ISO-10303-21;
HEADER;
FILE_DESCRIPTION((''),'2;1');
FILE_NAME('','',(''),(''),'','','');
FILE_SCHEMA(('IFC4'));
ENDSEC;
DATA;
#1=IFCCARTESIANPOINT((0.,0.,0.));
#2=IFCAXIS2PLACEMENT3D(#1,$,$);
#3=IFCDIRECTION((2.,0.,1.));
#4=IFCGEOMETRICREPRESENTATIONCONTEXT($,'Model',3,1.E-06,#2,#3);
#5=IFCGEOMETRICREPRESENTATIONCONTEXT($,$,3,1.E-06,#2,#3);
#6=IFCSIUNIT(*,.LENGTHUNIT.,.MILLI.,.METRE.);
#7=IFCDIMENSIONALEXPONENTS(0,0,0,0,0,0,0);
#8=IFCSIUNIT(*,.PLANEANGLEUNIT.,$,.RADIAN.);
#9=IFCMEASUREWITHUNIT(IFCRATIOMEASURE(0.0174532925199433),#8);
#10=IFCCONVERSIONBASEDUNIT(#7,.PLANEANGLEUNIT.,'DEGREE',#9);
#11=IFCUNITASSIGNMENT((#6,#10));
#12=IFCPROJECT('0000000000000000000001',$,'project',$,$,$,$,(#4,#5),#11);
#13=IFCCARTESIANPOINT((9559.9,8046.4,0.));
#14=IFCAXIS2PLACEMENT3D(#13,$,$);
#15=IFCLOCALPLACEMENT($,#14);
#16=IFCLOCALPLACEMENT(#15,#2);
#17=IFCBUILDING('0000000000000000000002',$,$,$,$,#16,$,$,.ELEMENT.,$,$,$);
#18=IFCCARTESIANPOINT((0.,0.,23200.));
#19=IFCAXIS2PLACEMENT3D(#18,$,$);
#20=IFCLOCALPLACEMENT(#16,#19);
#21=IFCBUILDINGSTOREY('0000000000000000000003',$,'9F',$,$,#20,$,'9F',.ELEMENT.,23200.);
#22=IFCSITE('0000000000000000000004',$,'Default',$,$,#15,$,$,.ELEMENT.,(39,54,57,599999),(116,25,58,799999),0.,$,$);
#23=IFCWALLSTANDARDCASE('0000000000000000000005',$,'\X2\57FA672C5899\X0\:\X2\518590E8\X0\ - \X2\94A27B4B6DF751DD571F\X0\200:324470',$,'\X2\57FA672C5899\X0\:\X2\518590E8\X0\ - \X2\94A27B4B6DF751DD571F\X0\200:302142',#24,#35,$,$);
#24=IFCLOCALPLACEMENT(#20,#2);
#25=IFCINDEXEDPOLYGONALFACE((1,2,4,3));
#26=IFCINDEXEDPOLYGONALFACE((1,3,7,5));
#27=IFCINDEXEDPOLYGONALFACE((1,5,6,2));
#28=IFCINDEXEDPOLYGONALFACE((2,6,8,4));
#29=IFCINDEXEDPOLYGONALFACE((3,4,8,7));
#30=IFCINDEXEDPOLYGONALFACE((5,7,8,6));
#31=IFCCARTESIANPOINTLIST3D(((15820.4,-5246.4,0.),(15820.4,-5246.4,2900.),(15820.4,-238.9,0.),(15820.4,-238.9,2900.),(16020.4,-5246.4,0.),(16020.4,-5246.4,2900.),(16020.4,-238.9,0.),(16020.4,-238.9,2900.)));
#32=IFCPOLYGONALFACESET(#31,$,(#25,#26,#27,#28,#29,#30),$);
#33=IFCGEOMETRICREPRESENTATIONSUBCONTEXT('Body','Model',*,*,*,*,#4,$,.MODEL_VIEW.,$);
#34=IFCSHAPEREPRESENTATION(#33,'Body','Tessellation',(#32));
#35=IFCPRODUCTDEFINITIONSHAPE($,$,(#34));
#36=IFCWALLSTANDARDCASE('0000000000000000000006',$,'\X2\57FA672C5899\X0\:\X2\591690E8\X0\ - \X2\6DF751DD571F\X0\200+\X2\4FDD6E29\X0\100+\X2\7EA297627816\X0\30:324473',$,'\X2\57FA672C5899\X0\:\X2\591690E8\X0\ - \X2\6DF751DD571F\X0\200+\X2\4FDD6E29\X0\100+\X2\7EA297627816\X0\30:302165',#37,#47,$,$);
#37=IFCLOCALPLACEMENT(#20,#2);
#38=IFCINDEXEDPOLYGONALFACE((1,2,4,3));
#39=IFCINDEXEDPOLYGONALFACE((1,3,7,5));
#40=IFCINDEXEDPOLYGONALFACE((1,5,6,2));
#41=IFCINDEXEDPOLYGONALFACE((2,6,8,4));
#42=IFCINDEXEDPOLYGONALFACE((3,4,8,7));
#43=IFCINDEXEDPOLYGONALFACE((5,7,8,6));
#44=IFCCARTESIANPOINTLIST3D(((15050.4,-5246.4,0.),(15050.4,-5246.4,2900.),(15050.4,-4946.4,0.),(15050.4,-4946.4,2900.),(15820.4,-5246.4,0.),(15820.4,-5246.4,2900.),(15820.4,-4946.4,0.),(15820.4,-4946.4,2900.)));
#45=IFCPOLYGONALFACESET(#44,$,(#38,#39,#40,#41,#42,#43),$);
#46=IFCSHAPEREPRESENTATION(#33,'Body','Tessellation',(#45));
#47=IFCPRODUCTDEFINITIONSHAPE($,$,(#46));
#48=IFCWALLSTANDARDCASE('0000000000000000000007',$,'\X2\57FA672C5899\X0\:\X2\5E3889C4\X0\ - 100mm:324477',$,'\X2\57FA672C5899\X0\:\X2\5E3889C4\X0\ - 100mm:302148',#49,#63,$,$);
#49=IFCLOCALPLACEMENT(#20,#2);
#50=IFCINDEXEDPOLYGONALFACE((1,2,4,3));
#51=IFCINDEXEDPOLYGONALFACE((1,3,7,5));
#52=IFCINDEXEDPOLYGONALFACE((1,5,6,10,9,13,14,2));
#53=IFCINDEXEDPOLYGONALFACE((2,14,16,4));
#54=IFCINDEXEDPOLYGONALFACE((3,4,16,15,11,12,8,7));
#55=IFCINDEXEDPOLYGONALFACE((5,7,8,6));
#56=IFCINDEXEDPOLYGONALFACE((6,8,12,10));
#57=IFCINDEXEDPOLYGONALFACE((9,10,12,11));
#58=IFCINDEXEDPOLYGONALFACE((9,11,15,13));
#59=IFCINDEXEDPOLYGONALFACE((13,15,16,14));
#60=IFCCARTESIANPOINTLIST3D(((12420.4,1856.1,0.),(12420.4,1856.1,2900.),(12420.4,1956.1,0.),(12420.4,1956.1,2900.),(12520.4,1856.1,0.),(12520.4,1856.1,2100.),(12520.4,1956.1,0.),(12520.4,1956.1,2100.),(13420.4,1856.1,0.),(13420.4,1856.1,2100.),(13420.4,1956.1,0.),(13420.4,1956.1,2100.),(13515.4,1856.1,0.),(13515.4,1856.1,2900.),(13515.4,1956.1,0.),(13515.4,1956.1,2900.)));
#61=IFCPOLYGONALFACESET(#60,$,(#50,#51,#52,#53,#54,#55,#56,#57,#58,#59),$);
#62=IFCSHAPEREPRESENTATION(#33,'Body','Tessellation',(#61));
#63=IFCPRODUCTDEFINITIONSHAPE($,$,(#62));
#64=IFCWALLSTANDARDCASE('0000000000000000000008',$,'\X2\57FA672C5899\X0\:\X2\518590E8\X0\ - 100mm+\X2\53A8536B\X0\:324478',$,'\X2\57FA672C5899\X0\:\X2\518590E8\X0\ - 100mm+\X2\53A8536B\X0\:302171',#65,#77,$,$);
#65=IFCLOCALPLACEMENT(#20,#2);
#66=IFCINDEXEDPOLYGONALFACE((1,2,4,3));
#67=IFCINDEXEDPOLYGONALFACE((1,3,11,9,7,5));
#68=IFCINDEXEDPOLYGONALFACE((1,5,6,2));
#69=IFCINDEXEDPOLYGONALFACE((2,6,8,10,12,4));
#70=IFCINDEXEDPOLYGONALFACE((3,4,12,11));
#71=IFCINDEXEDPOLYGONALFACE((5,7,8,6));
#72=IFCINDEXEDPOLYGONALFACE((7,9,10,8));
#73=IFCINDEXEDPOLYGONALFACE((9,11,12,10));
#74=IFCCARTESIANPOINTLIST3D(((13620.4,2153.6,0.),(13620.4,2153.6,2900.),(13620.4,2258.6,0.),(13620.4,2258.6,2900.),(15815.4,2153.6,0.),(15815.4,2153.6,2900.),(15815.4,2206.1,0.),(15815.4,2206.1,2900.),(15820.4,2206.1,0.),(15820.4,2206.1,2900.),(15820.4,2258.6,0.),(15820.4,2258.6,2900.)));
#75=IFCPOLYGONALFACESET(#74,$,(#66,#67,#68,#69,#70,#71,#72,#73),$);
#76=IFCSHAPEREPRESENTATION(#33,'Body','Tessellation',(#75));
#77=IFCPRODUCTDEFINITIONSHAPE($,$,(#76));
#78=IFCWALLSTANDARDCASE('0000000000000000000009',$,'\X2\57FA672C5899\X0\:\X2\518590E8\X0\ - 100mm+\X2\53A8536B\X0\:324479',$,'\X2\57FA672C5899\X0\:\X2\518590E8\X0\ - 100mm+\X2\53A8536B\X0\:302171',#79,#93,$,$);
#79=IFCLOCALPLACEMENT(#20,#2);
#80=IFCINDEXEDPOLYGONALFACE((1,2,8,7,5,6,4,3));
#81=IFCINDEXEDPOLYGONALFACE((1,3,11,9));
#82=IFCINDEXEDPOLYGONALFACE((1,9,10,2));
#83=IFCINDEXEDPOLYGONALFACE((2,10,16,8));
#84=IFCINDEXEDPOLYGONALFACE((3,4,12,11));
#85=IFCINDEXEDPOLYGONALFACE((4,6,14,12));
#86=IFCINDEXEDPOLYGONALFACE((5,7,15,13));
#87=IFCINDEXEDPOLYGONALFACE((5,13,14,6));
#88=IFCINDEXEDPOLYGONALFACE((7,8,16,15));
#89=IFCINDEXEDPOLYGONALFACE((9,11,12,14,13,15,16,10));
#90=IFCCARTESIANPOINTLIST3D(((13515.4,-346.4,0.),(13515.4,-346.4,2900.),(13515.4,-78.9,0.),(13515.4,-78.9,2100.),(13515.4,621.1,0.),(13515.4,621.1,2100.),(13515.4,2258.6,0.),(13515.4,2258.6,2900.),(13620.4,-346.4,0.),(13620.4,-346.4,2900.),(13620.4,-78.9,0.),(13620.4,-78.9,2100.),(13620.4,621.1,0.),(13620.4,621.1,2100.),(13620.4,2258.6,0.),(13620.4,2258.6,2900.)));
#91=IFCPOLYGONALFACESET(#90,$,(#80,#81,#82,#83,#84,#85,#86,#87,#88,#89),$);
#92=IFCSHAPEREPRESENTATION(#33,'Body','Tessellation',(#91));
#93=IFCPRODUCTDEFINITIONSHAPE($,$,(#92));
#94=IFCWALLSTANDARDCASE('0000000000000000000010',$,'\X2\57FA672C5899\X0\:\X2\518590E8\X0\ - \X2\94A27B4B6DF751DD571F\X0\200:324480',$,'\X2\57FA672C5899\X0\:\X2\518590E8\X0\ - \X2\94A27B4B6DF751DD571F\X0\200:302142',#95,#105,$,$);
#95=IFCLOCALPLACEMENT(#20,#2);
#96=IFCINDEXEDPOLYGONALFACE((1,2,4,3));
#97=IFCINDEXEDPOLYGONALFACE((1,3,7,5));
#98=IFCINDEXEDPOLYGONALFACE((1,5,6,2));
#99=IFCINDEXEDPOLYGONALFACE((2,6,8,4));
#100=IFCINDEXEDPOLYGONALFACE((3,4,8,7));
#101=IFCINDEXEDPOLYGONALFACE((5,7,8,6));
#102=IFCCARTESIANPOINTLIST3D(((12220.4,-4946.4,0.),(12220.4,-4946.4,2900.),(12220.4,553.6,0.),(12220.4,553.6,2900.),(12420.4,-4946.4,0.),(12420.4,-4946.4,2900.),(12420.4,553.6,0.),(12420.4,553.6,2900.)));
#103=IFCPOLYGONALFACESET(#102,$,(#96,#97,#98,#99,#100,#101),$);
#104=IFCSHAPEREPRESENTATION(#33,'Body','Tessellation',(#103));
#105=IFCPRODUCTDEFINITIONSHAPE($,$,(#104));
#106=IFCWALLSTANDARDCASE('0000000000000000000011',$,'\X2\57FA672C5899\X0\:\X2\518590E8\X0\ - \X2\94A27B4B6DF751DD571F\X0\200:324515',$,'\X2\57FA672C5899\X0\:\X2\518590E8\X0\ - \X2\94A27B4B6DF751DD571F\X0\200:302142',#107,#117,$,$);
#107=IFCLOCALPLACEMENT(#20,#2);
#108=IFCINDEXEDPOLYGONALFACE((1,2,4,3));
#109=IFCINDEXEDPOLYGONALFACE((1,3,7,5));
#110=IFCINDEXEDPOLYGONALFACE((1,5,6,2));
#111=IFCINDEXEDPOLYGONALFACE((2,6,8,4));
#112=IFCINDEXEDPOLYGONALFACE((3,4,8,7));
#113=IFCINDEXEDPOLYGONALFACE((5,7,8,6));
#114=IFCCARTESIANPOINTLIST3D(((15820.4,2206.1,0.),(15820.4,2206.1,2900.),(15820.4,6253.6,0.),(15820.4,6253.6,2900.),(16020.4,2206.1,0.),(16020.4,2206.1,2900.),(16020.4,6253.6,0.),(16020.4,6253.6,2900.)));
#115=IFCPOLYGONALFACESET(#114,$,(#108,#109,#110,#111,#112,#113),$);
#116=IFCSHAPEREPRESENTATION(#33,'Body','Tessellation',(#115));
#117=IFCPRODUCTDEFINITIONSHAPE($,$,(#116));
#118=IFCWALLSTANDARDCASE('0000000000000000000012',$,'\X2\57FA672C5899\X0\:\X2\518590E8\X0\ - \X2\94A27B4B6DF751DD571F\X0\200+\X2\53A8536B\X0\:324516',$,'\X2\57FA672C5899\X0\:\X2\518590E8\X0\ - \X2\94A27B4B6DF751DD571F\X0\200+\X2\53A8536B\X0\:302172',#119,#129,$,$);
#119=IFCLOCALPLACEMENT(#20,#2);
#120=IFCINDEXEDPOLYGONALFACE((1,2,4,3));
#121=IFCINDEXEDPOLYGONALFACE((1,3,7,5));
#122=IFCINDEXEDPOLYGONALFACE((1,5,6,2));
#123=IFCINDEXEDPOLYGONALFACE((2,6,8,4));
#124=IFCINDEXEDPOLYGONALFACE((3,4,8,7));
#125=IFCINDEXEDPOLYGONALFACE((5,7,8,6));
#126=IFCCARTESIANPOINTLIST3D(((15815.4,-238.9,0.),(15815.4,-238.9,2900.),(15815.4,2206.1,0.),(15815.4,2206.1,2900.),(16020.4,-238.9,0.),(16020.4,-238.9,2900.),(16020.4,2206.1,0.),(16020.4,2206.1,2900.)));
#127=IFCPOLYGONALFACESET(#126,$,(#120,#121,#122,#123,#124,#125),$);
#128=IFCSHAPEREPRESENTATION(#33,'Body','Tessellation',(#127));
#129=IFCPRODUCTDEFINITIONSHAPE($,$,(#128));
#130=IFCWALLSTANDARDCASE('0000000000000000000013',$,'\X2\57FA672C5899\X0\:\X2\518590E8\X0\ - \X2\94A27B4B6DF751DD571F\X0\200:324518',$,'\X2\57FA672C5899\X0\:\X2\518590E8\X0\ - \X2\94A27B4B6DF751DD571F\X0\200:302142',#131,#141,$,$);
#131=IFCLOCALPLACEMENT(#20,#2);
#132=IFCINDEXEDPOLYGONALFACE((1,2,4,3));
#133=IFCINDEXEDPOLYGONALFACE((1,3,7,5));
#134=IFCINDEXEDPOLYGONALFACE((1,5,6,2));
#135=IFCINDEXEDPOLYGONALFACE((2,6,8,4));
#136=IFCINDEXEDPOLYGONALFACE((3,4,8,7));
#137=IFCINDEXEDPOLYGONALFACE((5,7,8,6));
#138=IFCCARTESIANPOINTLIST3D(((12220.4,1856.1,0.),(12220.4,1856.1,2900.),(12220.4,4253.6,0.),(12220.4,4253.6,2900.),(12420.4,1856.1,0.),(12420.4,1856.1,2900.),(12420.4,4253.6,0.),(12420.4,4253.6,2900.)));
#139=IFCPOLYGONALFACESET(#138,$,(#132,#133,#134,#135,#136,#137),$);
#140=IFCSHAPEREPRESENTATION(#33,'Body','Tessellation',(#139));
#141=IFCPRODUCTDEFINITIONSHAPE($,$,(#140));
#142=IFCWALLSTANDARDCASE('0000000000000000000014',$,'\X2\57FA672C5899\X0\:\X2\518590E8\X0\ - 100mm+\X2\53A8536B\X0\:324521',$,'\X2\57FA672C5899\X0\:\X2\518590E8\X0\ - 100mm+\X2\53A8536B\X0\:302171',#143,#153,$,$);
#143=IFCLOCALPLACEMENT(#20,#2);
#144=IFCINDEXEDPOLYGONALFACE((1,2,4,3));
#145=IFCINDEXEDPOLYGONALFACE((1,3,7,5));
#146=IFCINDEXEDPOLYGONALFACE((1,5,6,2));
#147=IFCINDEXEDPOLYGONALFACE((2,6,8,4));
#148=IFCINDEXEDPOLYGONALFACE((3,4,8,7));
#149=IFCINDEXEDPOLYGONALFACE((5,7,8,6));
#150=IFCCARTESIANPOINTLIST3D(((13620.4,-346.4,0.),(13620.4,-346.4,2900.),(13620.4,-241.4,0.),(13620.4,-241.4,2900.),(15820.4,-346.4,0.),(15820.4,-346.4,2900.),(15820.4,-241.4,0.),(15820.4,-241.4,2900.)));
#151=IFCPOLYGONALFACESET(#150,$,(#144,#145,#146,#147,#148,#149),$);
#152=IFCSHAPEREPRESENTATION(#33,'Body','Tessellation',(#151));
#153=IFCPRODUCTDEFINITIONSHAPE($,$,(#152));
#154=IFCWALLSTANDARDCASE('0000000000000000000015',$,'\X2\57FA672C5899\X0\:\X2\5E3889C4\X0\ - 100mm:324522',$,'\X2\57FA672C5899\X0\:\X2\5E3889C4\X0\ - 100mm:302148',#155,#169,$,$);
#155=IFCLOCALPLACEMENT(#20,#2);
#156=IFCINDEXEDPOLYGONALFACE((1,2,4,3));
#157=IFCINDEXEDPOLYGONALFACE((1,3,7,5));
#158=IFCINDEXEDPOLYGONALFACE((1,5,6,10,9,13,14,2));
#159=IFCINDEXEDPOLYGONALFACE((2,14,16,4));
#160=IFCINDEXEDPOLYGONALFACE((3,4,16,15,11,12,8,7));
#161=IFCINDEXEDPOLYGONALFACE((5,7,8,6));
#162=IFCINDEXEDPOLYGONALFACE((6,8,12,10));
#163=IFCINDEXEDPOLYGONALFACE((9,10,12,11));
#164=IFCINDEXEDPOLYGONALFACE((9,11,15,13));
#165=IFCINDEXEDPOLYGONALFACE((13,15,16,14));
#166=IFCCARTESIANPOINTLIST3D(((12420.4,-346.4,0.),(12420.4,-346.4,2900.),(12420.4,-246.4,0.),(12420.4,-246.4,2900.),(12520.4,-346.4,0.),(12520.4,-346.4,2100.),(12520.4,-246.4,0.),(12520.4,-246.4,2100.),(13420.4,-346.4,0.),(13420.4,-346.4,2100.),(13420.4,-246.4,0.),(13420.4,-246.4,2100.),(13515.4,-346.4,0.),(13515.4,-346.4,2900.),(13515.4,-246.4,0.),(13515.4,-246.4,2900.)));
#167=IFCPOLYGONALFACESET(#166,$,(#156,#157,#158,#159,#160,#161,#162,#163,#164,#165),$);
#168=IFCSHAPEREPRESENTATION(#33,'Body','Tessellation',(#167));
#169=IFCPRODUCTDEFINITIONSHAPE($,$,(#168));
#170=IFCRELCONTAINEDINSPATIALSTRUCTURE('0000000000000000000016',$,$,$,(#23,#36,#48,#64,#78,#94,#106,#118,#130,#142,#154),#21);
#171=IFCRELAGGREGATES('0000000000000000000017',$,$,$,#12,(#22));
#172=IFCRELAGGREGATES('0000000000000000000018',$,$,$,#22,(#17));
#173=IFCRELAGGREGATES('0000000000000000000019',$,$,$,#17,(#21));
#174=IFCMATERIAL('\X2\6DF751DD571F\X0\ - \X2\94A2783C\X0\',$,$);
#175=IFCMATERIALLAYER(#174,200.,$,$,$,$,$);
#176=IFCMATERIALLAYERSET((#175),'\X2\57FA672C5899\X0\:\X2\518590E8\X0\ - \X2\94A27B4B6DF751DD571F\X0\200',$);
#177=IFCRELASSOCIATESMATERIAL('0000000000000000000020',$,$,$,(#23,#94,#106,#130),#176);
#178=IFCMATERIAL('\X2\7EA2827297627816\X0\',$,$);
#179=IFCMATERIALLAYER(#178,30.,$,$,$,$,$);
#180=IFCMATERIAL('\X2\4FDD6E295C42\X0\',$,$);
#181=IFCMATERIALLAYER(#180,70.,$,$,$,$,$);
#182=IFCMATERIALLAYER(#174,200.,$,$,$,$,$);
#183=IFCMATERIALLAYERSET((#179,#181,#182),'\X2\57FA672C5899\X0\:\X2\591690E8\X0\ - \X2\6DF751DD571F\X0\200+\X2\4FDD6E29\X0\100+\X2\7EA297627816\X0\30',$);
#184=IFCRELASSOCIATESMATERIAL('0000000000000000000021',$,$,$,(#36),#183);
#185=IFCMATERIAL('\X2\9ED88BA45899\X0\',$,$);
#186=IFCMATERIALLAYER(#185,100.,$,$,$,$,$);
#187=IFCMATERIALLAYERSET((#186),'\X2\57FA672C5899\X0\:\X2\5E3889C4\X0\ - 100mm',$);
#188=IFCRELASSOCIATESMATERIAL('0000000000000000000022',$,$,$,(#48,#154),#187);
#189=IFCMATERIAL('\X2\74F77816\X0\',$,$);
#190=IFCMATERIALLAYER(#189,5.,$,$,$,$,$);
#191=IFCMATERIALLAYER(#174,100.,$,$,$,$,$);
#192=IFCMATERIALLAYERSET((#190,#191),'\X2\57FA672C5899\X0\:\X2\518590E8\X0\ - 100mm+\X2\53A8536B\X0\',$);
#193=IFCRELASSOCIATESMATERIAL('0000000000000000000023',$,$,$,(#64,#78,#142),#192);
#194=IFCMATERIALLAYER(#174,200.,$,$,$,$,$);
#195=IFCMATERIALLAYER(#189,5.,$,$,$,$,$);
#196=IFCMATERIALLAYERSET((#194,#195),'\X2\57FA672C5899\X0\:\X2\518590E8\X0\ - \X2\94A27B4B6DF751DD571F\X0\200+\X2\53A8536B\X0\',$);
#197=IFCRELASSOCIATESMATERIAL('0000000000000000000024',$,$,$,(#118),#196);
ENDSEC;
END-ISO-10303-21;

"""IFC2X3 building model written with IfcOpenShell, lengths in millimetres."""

from ifc_helpers import new_model, entity, si_unit, converted_unit, direction, frame, frame_2d, origin, place, context, subcontext, project, spatial, polyline, rectangle, outline, extrude, material, layer, layer_set, layer_usage, element, save


model = new_model("IFC2X3")

# Units and contexts
model_context = context("Model", 3, precision=1e-06, world=origin(), true_north=direction((2.0, 0.0, 1.0)))
context_of_model = context(None, 3, precision=1e-06, world=origin(), true_north=direction((2.0, 0.0, 1.0)))
body_context = subcontext(model_context, "Body", "Model", "MODEL_VIEW")
ifc_project = project(units=[si_unit("LENGTHUNIT", "METRE", prefix="MILLI"), converted_unit("PLANEANGLEUNIT", "DEGREE", entity("IfcRatioMeasure", 0.0174532925199433), si_unit("PLANEANGLEUNIT", "RADIAN"), dimensions=[0, 0, 0, 0, 0, 0, 0])], contexts=[model_context, context_of_model])

# Site, building, storey
site_placement = place(None, frame((9559.9, 8046.4, 0.0)))
site = spatial("IfcSite", under=ifc_project, at=site_placement, Name="Default", CompositionType="ELEMENT", RefLatitude=(39, 54, 57, 599999), RefLongitude=(116, 25, 58, 799999), RefElevation=0.0)
building_placement = place(site_placement, origin())
building = spatial("IfcBuilding", under=site, at=building_placement, CompositionType="ELEMENT")
storey_placement = place(building_placement, frame((0.0, 0.0, 23200.0)))
storey = spatial("IfcBuildingStorey", under=building, at=storey_placement, Name="9F", LongName="9F", CompositionType="ELEMENT", Elevation=23200.0)

# Walls
ifc_material_1 = material(Name="混凝土 - 钢砼")
ifc_layer_1 = layer(ifc_material_1, 200.0)
ifc_layer_set_1 = layer_set([ifc_layer_1], Name="基本墙:内部 - 钢筋混凝土200")
ifc_layer_usage_1 = layer_usage(ifc_layer_set_1, "AXIS2", "POSITIVE", -100.0)
wall_1_placement = place(storey_placement, frame((15920.4, -5246.4, 0.0), z_axis=(0.0, 0.0, 1.0), x_axis=(0.0, 1.0, 0.0)))
element("IfcWallStandardCase", 1, at=wall_1_placement, inside=storey, material=ifc_layer_usage_1, Name="基本墙:内部 - 钢筋混凝土200:324470", ObjectType="基本墙:内部 - 钢筋混凝土200:302142", context=body_context, shape_type="SweptSolid", body=[
    extrude(rectangle(XDim=5007.5, YDim=200.0, at=frame_2d((2503.8, 0.0), x_axis=(-1.0, 0.0))), origin(), (0.0, 0.0, 1.0), 2900.0),
])
ifc_material_2 = material(Name="红色面砖")
ifc_layer_2 = layer(ifc_material_2, 30.0)
ifc_material_3 = material(Name="保温层")
ifc_layer_3 = layer(ifc_material_3, 70.0)
ifc_layer_4 = layer(ifc_material_1, 200.0)
ifc_layer_set_2 = layer_set([ifc_layer_2, ifc_layer_3, ifc_layer_4], Name="基本墙:外部 - 混凝土200+保温100+红面砖30")
ifc_layer_usage_2 = layer_usage(ifc_layer_set_2, "AXIS2", "NEGATIVE", 150.0)
wall_2_placement = place(storey_placement, frame((15820.4, -5096.4, 0.0), z_axis=(0.0, 0.0, 1.0), x_axis=(-1.0, 0.0, 0.0)))
element("IfcWallStandardCase", 2, at=wall_2_placement, inside=storey, material=ifc_layer_usage_2, Name="基本墙:外部 - 混凝土200+保温100+红面砖30:324473", ObjectType="基本墙:外部 - 混凝土200+保温100+红面砖30:302165", context=body_context, shape_type="SweptSolid", body=[
    extrude(rectangle(XDim=770.0, YDim=300.0, at=frame_2d((385.0, 0.0), x_axis=(-1.0, 0.0))), origin(), (0.0, 0.0, 1.0), 2900.0),
])

# Wall, opening
ifc_material_4 = material(Name="默认墙")
ifc_layer_5 = layer(ifc_material_4, 100.0)
ifc_layer_set_3 = layer_set([ifc_layer_5], Name="基本墙:常规 - 100mm")
ifc_layer_usage_3 = layer_usage(ifc_layer_set_3, "AXIS2", "POSITIVE", -50.0)
wall_3_placement = place(storey_placement, frame((13515.4, 1906.1, 0.0), z_axis=(0.0, 0.0, 1.0), x_axis=(-1.0, 0.0, 0.0)))
wall_3 = element("IfcWallStandardCase", 3, at=wall_3_placement, inside=storey, material=ifc_layer_usage_3, Name="基本墙:常规 - 100mm:324477", ObjectType="基本墙:常规 - 100mm:302148", context=body_context, shape_type="SweptSolid", body=[
    extrude(rectangle(XDim=1095.0, YDim=100.0, at=frame_2d((547.5, 0.0), x_axis=(-1.0, 0.0))), origin(), (0.0, 0.0, 1.0), 2900.0),
])
opening_1_placement = place(wall_3_placement, frame((995.0, 50.0, 0.0)))
element("IfcOpeningElement", 4, at=opening_1_placement, cuts=wall_3, ObjectType="Opening", context=body_context, shape_type="SweptSolid", body=[
    extrude(rectangle(XDim=2100.0, YDim=900.0, at=frame_2d((1050.0, 450.0), x_axis=(1.0, 0.0))), frame((0.0, 0.0, 0.0), z_axis=(0.0, -1.0, 0.0), x_axis=(0.0, 0.0, 1.0)), (0.0, 0.0, 1.0), 100.0),
])

# Wall
ifc_material_5 = material(Name="瓷砖")
ifc_layer_6 = layer(ifc_material_5, 5.0)
ifc_layer_7 = layer(ifc_material_1, 100.0)
ifc_layer_set_4 = layer_set([ifc_layer_6, ifc_layer_7], Name="基本墙:内部 - 100mm+厨卫")
ifc_layer_usage_4 = layer_usage(ifc_layer_set_4, "AXIS2", "NEGATIVE", 52.5)
wall_4_placement = place(storey_placement, frame((15820.4, 2206.1, 0.0), z_axis=(0.0, 0.0, 1.0), x_axis=(-1.0, 0.0, 0.0)))
element("IfcWallStandardCase", 5, at=wall_4_placement, inside=storey, material=ifc_layer_usage_4, Name="基本墙:内部 - 100mm+厨卫:324478", ObjectType="基本墙:内部 - 100mm+厨卫:302171", context=body_context, shape_type="SweptSolid", body=[
    extrude(outline(polyline([(2200.0, -52.5), (2200.0, 52.5), (5.0, 52.5), (5.0, 0.0), (0.0, 0.0), (0.0, -52.5), (2200.0, -52.5)])), origin(), (0.0, 0.0, 1.0), 2900.0),
])

# Wall, opening
ifc_layer_usage_5 = layer_usage(ifc_layer_set_4, "AXIS2", "NEGATIVE", 52.5)
wall_5_placement = place(storey_placement, frame((13567.9, 2258.6, 0.0), z_axis=(0.0, 0.0, 1.0), x_axis=(0.0, -1.0, 0.0)))
wall_5 = element("IfcWallStandardCase", 6, at=wall_5_placement, inside=storey, material=ifc_layer_usage_5, Name="基本墙:内部 - 100mm+厨卫:324479", ObjectType="基本墙:内部 - 100mm+厨卫:302171", context=body_context, shape_type="SweptSolid", body=[
    extrude(rectangle(XDim=2605.0, YDim=105.0, at=frame_2d((1302.5, 0.0), x_axis=(-1.0, 0.0))), origin(), (0.0, 0.0, 1.0), 2900.0),
])
opening_2_placement = place(wall_5_placement, frame((1637.5, -52.5, 0.0)))
element("IfcOpeningElement", 7, at=opening_2_placement, cuts=wall_5, ObjectType="Opening", context=body_context, shape_type="SweptSolid", body=[
    extrude(rectangle(XDim=2100.0, YDim=700.0, at=frame_2d((1050.0, 350.0), x_axis=(1.0, 0.0))), frame((0.0, 0.0, 0.0), z_axis=(0.0, 1.0, 0.0), x_axis=(0.0, 0.0, 1.0)), (0.0, 0.0, 1.0), 105.0),
])

# Walls
ifc_layer_usage_6 = layer_usage(ifc_layer_set_1, "AXIS2", "NEGATIVE", 100.0)
wall_6_placement = place(storey_placement, frame((12320.4, 553.6, 0.0), z_axis=(0.0, 0.0, 1.0), x_axis=(0.0, -1.0, 0.0)))
element("IfcWallStandardCase", 8, at=wall_6_placement, inside=storey, material=ifc_layer_usage_6, Name="基本墙:内部 - 钢筋混凝土200:324480", ObjectType="基本墙:内部 - 钢筋混凝土200:302142", context=body_context, shape_type="SweptSolid", body=[
    extrude(rectangle(XDim=5500.0, YDim=200.0, at=frame_2d((2750.0, 0.0), x_axis=(-1.0, 0.0))), origin(), (0.0, 0.0, 1.0), 2900.0),
])
ifc_layer_usage_7 = layer_usage(ifc_layer_set_1, "AXIS2", "POSITIVE", -100.0)
wall_7_placement = place(storey_placement, frame((15920.4, 2206.1, 0.0), z_axis=(0.0, 0.0, 1.0), x_axis=(0.0, 1.0, 0.0)))
element("IfcWallStandardCase", 9, at=wall_7_placement, inside=storey, material=ifc_layer_usage_7, Name="基本墙:内部 - 钢筋混凝土200:324515", ObjectType="基本墙:内部 - 钢筋混凝土200:302142", context=body_context, shape_type="SweptSolid", body=[
    extrude(rectangle(XDim=4047.5, YDim=200.0, at=frame_2d((2023.8, 0.0), x_axis=(-1.0, 0.0))), origin(), (0.0, 0.0, 1.0), 2900.0),
])
ifc_layer_8 = layer(ifc_material_1, 200.0)
ifc_layer_9 = layer(ifc_material_5, 5.0)
ifc_layer_set_5 = layer_set([ifc_layer_8, ifc_layer_9], Name="基本墙:内部 - 钢筋混凝土200+厨卫")
ifc_layer_usage_8 = layer_usage(ifc_layer_set_5, "AXIS2", "POSITIVE", -102.5)
wall_8_placement = place(storey_placement, frame((15917.9, -238.9, 0.0), z_axis=(0.0, 0.0, 1.0), x_axis=(0.0, 1.0, 0.0)))
element("IfcWallStandardCase", 10, at=wall_8_placement, inside=storey, material=ifc_layer_usage_8, Name="基本墙:内部 - 钢筋混凝土200+厨卫:324516", ObjectType="基本墙:内部 - 钢筋混凝土200+厨卫:302172", context=body_context, shape_type="SweptSolid", body=[
    extrude(rectangle(XDim=2445.0, YDim=205.0, at=frame_2d((1222.5, 0.0), x_axis=(-1.0, 0.0))), origin(), (0.0, 0.0, 1.0), 2900.0),
])
ifc_layer_usage_9 = layer_usage(ifc_layer_set_1, "AXIS2", "POSITIVE", -100.0)
wall_9_placement = place(storey_placement, frame((12320.4, 4253.6, 0.0), z_axis=(0.0, 0.0, 1.0), x_axis=(0.0, -1.0, 0.0)))
element("IfcWallStandardCase", 11, at=wall_9_placement, inside=storey, material=ifc_layer_usage_9, Name="基本墙:内部 - 钢筋混凝土200:324518", ObjectType="基本墙:内部 - 钢筋混凝土200:302142", context=body_context, shape_type="SweptSolid", body=[
    extrude(rectangle(XDim=2397.5, YDim=200.0, at=frame_2d((1198.8, 0.0), x_axis=(-1.0, 0.0))), origin(), (0.0, 0.0, 1.0), 2900.0),
])
ifc_layer_usage_10 = layer_usage(ifc_layer_set_4, "AXIS2", "POSITIVE", -52.5)
wall_10_placement = place(storey_placement, frame((15820.4, -293.9, 0.0), z_axis=(0.0, 0.0, 1.0), x_axis=(-1.0, 0.0, 0.0)))
element("IfcWallStandardCase", 12, at=wall_10_placement, inside=storey, material=ifc_layer_usage_10, Name="基本墙:内部 - 100mm+厨卫:324521", ObjectType="基本墙:内部 - 100mm+厨卫:302171", context=body_context, shape_type="SweptSolid", body=[
    extrude(rectangle(XDim=2200.0, YDim=105.0, at=frame_2d((1100.0, 0.0), x_axis=(-1.0, 0.0))), origin(), (0.0, 0.0, 1.0), 2900.0),
])

# Wall, opening
ifc_layer_usage_11 = layer_usage(ifc_layer_set_3, "AXIS2", "POSITIVE", -50.0)
wall_11_placement = place(storey_placement, frame((13515.4, -296.4, 0.0), z_axis=(0.0, 0.0, 1.0), x_axis=(-1.0, 0.0, 0.0)))
wall_11 = element("IfcWallStandardCase", 13, at=wall_11_placement, inside=storey, material=ifc_layer_usage_11, Name="基本墙:常规 - 100mm:324522", ObjectType="基本墙:常规 - 100mm:302148", context=body_context, shape_type="SweptSolid", body=[
    extrude(rectangle(XDim=1095.0, YDim=100.0, at=frame_2d((547.5, 0.0), x_axis=(-1.0, 0.0))), origin(), (0.0, 0.0, 1.0), 2900.0),
])
opening_3_placement = place(wall_11_placement, frame((95.0, -50.0, 0.0)))
element("IfcOpeningElement", 14, at=opening_3_placement, cuts=wall_11, ObjectType="Opening", context=body_context, shape_type="SweptSolid", body=[
    extrude(rectangle(XDim=2100.0, YDim=900.0, at=frame_2d((1050.0, 450.0), x_axis=(1.0, 0.0))), frame((0.0, 0.0, 0.0), z_axis=(0.0, 1.0, 0.0), x_axis=(0.0, 0.0, 1.0)), (0.0, 0.0, 1.0), 100.0),
])

save(model, "model.ifc")
